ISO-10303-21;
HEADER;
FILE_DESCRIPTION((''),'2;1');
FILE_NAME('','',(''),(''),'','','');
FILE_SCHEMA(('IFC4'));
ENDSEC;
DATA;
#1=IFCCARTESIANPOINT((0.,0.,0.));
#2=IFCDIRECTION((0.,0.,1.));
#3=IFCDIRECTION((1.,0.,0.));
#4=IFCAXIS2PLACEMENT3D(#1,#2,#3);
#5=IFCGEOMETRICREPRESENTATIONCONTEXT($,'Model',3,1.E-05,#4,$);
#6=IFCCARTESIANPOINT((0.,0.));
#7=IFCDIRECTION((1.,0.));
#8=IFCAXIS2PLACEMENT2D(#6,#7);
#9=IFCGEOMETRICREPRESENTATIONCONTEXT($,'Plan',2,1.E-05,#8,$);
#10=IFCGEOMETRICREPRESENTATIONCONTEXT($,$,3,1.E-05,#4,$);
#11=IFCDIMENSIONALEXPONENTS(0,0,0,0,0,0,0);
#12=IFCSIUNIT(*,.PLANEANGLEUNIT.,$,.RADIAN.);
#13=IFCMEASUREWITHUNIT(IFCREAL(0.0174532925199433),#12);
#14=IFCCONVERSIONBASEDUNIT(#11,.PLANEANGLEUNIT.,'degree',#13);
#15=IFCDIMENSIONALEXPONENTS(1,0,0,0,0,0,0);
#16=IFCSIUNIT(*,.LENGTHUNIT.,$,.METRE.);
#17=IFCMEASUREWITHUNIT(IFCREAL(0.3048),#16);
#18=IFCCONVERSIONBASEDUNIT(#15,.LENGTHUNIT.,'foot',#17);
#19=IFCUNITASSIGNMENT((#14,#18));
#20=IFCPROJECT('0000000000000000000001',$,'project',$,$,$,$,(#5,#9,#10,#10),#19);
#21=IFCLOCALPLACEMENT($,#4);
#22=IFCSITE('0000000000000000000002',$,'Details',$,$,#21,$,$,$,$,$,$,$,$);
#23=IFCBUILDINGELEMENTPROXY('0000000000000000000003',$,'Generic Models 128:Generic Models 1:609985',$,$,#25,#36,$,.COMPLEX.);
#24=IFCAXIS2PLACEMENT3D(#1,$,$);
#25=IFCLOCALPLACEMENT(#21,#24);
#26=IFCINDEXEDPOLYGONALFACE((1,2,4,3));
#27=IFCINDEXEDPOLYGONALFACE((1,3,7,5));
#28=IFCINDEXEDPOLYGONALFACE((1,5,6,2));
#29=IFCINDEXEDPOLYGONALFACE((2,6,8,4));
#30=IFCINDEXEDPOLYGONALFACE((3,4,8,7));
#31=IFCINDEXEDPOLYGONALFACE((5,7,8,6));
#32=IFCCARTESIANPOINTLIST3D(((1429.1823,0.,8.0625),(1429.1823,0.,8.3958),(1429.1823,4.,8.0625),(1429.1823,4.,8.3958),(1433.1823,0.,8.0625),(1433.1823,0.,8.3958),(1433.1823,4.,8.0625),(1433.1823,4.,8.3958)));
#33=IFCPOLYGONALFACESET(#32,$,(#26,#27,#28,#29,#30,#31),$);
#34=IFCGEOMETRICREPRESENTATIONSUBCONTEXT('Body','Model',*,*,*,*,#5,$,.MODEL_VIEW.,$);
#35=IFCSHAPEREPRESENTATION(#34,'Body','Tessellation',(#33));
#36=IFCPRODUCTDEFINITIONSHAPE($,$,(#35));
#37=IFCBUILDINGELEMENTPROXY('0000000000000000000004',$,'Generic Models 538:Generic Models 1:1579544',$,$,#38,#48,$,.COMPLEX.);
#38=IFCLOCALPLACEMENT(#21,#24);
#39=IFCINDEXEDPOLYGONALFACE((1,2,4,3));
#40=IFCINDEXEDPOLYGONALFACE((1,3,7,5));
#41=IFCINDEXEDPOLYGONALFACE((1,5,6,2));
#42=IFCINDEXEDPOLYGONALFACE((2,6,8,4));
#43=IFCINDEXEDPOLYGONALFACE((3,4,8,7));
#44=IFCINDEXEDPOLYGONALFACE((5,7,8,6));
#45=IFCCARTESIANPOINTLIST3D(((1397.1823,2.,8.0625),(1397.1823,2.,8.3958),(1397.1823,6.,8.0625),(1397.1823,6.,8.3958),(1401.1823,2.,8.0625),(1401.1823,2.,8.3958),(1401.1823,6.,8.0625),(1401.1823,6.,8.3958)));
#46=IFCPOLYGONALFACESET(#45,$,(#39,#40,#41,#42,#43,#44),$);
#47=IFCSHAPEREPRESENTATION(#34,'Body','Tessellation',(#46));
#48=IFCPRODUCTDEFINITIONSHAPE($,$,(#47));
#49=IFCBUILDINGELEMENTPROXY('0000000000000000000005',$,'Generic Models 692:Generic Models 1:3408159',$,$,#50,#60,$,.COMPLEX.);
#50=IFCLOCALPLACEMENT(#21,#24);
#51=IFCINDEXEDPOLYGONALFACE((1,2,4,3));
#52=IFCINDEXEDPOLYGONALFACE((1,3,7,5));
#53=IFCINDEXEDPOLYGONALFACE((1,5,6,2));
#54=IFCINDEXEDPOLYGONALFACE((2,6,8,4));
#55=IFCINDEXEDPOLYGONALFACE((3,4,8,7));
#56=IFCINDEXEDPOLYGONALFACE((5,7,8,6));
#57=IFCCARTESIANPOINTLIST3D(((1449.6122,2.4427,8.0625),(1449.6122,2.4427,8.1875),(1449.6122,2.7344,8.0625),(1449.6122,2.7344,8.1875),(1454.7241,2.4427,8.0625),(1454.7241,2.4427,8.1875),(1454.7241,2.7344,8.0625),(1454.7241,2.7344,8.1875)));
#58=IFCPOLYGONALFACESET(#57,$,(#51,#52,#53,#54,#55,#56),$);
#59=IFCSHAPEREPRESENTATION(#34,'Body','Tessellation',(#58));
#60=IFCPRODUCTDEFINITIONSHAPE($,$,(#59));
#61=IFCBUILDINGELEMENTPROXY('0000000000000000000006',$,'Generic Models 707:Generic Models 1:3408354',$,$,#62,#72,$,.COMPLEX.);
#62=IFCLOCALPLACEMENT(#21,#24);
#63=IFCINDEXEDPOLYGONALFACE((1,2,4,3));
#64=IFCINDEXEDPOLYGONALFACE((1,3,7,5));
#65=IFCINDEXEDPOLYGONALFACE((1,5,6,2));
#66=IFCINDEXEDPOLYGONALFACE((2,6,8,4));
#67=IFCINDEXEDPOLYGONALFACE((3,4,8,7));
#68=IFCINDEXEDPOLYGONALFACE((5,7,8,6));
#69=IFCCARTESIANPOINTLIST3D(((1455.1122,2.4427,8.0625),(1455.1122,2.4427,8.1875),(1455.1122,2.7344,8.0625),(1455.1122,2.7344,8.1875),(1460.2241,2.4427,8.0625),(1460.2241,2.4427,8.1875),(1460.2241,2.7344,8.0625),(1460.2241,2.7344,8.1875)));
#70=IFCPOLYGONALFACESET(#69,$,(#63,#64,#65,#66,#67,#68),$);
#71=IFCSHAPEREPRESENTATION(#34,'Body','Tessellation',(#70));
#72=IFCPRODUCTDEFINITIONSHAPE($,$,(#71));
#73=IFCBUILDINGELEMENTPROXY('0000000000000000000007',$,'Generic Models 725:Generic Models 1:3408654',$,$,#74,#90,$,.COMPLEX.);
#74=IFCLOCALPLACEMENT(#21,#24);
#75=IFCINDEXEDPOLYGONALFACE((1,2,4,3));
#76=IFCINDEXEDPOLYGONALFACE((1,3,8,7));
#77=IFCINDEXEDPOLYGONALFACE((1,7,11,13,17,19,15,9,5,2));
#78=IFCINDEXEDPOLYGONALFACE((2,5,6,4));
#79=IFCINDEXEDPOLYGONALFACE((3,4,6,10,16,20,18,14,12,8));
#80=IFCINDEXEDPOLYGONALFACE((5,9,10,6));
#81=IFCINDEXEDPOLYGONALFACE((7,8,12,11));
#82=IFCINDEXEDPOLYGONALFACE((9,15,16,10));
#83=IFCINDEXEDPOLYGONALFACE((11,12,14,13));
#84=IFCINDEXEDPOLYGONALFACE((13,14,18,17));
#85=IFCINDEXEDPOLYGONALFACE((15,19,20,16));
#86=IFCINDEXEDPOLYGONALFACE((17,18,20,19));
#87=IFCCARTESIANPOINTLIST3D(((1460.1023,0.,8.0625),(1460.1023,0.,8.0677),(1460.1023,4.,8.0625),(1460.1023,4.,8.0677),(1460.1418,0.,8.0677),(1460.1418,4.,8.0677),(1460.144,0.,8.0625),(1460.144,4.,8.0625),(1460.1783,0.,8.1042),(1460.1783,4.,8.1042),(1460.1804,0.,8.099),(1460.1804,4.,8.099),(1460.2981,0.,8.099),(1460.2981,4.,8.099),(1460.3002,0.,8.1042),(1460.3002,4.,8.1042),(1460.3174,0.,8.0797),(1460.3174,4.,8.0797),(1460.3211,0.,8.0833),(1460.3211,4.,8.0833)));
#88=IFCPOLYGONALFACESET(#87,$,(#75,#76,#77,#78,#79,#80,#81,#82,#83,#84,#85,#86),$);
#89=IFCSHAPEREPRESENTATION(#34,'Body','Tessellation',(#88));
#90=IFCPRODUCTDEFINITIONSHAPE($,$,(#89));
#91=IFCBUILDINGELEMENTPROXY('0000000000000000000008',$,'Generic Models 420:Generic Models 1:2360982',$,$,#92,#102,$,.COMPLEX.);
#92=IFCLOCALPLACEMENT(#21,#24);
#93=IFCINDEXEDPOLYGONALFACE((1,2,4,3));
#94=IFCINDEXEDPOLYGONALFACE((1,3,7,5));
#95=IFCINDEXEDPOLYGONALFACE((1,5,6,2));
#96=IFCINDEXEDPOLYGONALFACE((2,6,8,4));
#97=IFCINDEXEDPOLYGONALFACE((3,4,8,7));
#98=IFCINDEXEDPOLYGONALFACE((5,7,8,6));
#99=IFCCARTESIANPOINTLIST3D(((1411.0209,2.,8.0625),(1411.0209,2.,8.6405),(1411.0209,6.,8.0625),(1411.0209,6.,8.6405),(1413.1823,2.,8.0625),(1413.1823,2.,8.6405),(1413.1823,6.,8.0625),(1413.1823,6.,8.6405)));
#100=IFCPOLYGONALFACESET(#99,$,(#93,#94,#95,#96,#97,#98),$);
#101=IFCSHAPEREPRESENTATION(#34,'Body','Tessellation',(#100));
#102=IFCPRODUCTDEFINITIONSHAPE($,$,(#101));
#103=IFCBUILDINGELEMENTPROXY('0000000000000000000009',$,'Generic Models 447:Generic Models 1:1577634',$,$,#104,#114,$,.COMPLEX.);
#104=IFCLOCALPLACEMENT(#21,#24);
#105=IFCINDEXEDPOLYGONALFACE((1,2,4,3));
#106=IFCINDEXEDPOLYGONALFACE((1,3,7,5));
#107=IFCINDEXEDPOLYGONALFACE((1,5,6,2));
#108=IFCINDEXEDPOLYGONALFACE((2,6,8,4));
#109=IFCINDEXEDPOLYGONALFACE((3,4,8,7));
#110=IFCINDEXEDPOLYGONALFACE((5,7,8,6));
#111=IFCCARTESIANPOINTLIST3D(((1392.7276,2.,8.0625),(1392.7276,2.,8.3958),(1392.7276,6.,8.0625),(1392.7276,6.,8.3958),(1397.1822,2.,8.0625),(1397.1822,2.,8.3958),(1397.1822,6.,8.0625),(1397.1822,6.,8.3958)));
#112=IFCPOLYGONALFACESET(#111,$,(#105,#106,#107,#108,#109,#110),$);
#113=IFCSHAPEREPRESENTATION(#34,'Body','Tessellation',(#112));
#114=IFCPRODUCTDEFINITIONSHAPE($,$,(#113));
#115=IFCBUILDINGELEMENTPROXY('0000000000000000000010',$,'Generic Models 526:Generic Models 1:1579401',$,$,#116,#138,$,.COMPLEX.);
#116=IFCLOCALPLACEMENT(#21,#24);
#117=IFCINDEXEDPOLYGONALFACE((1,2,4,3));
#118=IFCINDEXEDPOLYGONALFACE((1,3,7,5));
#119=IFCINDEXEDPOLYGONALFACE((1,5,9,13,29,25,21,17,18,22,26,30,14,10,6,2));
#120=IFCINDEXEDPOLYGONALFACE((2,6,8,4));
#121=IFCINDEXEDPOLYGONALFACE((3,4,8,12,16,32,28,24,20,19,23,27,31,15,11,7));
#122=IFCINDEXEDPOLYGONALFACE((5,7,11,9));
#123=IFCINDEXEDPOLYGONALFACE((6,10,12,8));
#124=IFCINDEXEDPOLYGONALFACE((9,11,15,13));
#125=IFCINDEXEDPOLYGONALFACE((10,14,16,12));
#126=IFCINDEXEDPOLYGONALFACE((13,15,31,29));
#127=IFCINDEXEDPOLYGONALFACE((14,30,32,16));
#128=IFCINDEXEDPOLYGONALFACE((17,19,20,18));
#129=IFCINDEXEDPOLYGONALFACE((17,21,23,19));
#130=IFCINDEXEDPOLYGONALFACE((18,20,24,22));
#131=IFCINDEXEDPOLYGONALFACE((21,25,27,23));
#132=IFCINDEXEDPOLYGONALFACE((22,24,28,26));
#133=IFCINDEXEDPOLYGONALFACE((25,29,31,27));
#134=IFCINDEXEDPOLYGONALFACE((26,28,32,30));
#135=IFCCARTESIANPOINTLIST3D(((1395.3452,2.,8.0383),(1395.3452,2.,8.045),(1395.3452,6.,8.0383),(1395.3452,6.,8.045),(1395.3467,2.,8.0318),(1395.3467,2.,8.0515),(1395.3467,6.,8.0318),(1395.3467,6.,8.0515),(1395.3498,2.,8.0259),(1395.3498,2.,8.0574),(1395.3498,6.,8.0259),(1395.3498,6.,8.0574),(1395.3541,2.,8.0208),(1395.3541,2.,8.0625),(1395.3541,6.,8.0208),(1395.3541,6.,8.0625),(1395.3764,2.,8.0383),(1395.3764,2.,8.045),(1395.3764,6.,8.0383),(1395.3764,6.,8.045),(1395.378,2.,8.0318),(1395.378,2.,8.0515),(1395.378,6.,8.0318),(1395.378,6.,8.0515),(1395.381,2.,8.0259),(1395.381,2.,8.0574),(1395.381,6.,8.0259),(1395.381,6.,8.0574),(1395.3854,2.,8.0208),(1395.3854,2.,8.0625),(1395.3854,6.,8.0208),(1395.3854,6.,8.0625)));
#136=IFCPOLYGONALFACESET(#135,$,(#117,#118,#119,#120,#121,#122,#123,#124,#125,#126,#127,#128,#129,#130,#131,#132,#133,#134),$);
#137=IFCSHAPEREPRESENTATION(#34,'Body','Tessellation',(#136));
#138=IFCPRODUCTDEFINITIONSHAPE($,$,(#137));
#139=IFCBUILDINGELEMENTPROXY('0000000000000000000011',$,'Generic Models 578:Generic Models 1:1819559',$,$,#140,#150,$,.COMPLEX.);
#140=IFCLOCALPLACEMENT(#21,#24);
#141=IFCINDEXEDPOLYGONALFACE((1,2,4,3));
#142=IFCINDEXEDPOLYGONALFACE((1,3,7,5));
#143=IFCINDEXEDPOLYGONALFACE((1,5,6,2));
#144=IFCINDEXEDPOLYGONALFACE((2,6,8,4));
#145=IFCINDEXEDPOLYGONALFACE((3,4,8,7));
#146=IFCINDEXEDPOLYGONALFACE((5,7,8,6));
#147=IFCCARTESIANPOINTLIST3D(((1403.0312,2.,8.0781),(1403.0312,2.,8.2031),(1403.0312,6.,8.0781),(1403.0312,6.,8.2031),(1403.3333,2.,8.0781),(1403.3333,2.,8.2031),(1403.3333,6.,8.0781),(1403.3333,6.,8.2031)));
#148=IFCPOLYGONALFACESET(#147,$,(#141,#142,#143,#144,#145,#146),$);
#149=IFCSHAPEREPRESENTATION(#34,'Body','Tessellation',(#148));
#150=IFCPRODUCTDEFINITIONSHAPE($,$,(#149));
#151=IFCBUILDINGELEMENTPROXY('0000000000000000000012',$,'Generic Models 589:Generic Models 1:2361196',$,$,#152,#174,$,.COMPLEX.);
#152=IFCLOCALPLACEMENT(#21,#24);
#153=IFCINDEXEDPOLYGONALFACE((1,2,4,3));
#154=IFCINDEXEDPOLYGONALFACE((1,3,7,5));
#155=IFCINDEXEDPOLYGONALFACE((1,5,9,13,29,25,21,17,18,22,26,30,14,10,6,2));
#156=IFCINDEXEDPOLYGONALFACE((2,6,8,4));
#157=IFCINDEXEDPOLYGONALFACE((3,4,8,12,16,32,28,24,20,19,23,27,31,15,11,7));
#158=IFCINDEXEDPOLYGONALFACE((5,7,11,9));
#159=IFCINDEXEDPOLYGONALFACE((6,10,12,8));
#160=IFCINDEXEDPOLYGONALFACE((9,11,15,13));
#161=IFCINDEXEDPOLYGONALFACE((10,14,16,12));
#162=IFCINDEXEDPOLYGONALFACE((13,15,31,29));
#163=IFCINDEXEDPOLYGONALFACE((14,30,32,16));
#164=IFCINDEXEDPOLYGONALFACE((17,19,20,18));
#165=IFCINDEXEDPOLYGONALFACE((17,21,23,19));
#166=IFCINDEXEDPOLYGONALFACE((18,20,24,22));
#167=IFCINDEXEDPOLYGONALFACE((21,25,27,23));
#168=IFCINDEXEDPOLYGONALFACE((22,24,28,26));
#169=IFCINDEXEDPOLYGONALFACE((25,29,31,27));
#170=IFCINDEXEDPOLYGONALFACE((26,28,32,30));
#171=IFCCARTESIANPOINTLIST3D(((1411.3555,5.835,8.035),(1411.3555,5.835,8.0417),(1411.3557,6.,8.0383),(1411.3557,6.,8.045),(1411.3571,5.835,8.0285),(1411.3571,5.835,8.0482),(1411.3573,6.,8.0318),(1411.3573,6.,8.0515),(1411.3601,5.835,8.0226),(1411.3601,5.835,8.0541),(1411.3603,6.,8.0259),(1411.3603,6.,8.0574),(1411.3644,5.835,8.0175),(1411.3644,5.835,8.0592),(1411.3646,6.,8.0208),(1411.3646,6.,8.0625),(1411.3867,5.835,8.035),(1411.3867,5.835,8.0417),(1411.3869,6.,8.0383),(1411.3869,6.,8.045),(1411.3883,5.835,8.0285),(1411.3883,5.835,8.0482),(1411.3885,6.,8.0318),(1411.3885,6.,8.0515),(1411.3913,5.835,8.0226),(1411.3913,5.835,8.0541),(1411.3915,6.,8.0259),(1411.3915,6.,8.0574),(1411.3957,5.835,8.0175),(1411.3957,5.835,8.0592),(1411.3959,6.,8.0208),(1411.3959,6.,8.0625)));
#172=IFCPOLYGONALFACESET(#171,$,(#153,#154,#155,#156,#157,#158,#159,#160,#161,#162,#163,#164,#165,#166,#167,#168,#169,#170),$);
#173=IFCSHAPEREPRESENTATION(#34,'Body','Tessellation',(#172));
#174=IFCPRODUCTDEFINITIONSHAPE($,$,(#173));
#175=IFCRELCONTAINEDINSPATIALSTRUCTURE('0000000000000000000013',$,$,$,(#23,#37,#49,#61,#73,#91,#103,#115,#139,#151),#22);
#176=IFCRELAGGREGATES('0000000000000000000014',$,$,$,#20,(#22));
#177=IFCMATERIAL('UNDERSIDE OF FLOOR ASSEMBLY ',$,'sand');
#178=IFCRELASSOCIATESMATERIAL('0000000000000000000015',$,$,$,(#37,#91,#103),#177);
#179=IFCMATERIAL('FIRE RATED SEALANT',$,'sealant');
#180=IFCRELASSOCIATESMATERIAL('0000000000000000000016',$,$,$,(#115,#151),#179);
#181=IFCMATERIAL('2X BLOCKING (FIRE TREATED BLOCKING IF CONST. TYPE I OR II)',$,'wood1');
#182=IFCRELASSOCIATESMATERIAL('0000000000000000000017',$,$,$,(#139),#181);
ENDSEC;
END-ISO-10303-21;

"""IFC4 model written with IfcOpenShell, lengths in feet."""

from ifc_helpers import new_model, entity, si_unit, converted_unit, frame, origin_with_axes, origin_2d_with_axis, place, context, subcontext, project, spatial, polyline, line, indexed_curve, outline, extrude, material, element, save


model = new_model("IFC4")

# Units and contexts
model_context = context("Model", 3, precision=1e-05, world=origin_with_axes())
plan_context = context("Plan", 2, precision=1e-05, world=origin_2d_with_axis())
context_of_model = context(None, 3, precision=1e-05, world=origin_with_axes())
body_context = subcontext(model_context, "Body", "Model", "MODEL_VIEW")
ifc_project = project(units=[converted_unit("PLANEANGLEUNIT", "degree", entity("IfcReal", 0.0174532925199433), si_unit("PLANEANGLEUNIT", "RADIAN"), dimensions=[0, 0, 0, 0, 0, 0, 0]), converted_unit("LENGTHUNIT", "foot", entity("IfcReal", 0.3048), si_unit("LENGTHUNIT", "METRE"), dimensions=[1, 0, 0, 0, 0, 0, 0])], contexts=[model_context, plan_context, context_of_model, context_of_model])

# Site
site_placement = place(None, origin_with_axes())
site = spatial("IfcSite", under=ifc_project, at=site_placement, Name="Details")

# Building element proxies
proxy_1_placement = place(site_placement, frame((1429.1823, 4.0, 8.0625), z_axis=(0.0, -1.0, 0.0), x_axis=(0.0, 0.0, 1.0)))
element("IfcBuildingElementProxy", 1, at=proxy_1_placement, inside=site, Name="Generic Models 128:Generic Models 1:609985", PredefinedType="COMPLEX", context=body_context, shape_type="SweptSolid", body=[
    extrude(outline(polyline([(-0.1667, -2.0), (0.1667, -2.0), (0.1667, 2.0), (-0.1667, 2.0), (-0.1667, -2.0)])), frame((0.1667, -2.0, 0.0), z_axis=(0.0, 0.0, -1.0), x_axis=(-1.0, 0.0, 0.0)), (0.0, 0.0, -1.0), 4.0),
])
ifc_material_1 = material(Name="UNDERSIDE OF FLOOR ASSEMBLY ", Category="sand")
proxy_2_placement = place(site_placement, frame((1397.1823, 6.0, 8.0625), z_axis=(0.0, -1.0, 0.0), x_axis=(0.0, 0.0, 1.0)))
element("IfcBuildingElementProxy", 2, at=proxy_2_placement, inside=site, material=ifc_material_1, Name="Generic Models 538:Generic Models 1:1579544", PredefinedType="COMPLEX", context=body_context, shape_type="SweptSolid", body=[
    extrude(outline(polyline([(-0.1667, -2.0), (0.1667, -2.0), (0.1667, 2.0), (-0.1667, 2.0), (-0.1667, -2.0)])), frame((0.1667, -2.0, 0.0), z_axis=(0.0, 0.0, -1.0), x_axis=(1.0, 0.0, 0.0)), (0.0, 0.0, -1.0), 4.0),
])
for number, where, z_axis, x_axis, name in (
    (3, (1449.6122, 2.7344, 8.0625), (0.0, -1.0, 0.0), (1.0, 0.0, 0.0), "Generic Models 692:Generic Models 1:3408159"),
    (4, (1455.1122, 2.7344, 8.0625), (0.0, -1.0, 0.0), (1.0, 0.0, 0.0), "Generic Models 707:Generic Models 1:3408354"),
):
    element("IfcBuildingElementProxy", number, at=place(site_placement, frame(where, z_axis=z_axis, x_axis=x_axis)), inside=site, Name=name, PredefinedType="COMPLEX", context=body_context, shape_type="SweptSolid", body=[
        extrude(outline(polyline([(-0.0625, -2.556), (0.0625, -2.556), (0.0625, 2.556), (-0.0625, 2.556), (-0.0625, -2.556)])), frame((2.556, 0.0625, 0.0), z_axis=(0.0, 0.0, -1.0), x_axis=(0.0, 1.0, 0.0)), (0.0, 0.0, -1.0), 0.2917),
    ])
proxy_3_placement = place(site_placement, frame((1460.1023, 4.0, 8.0625), z_axis=(0.0, -1.0, 0.0), x_axis=(0.0, 0.0, 1.0)))
element("IfcBuildingElementProxy", 5, at=proxy_3_placement, inside=site, Name="Generic Models 725:Generic Models 1:3408654", PredefinedType="COMPLEX", context=body_context, shape_type="SweptSolid", body=[
    extrude(outline(polyline([(0.1082, 0.0), (0.1072, 0.0051), (0.0684, -0.0024), (0.0258, 0.0266), (-0.094, 0.0035), (-0.1105, -0.0209), (-0.1062, -0.0238), (-0.0909, -0.0012), (0.0246, 0.021), (0.0673, -0.0079), (0.1082, 0.0)])), frame((0.0205, -0.1063, 0.0), z_axis=(0.0, 0.0, -1.0), x_axis=(-0.189091, 0.98196, 0.0)), (0.0, 0.0, -1.0), 4.0),
])
proxy_4_placement = place(site_placement, frame((1411.0209, 6.0, 8.0625), z_axis=(0.0, -1.0, 0.0), x_axis=(0.0, 0.0, 1.0)))
element("IfcBuildingElementProxy", 6, at=proxy_4_placement, inside=site, material=ifc_material_1, Name="Generic Models 420:Generic Models 1:2360982", PredefinedType="COMPLEX", context=body_context, shape_type="SweptSolid", body=[
    extrude(outline(polyline([(-0.289, -1.0807), (0.289, -1.0807), (0.289, 1.0807), (-0.289, 1.0807), (-0.289, -1.0807)])), frame((0.289, -1.0807, 0.0), z_axis=(0.0, 0.0, -1.0), x_axis=(1.0, 0.0, 0.0)), (0.0, 0.0, -1.0), 4.0),
])
proxy_5_placement = place(site_placement, frame((1392.7276, 6.0, 8.0625), z_axis=(0.0, -1.0, 0.0), x_axis=(0.0, 0.0, 1.0)))
element("IfcBuildingElementProxy", 7, at=proxy_5_placement, inside=site, material=ifc_material_1, Name="Generic Models 447:Generic Models 1:1577634", PredefinedType="COMPLEX", context=body_context, shape_type="SweptSolid", body=[
    extrude(outline(indexed_curve([(-2.4546, -0.1667), (2.0, -0.1667), (2.0, 0.1667), (-2.4546, 0.1667)], segments=[line(3, 2), line(2, 1), line(1, 4), line(4, 3)], self_intersect=False)), frame((0.1667, -2.0, 0.0), z_axis=(0.0, 0.0, -1.0), x_axis=(0.0, 1.0, 0.0)), (0.0, 0.0, -1.0), 4.0),
])
ifc_material_2 = material(Name="FIRE RATED SEALANT", Category="sealant")
proxy_6_placement = place(site_placement, frame((1395.3854, 6.0, 8.0625), z_axis=(0.0, -1.0, 0.0), x_axis=(0.0, 0.0, -1.0)))
element("IfcBuildingElementProxy", 8, at=proxy_6_placement, inside=site, material=ifc_material_2, Name="Generic Models 526:Generic Models 1:1579401", PredefinedType="COMPLEX", context=body_context, shape_type="SweptSolid", body=[
    extrude(outline(polyline([(0.0216, 0.0), (0.0223, 0.0066), (0.001, 0.0294), (0.0002, 0.0228), (-0.002, 0.0165), (-0.0057, 0.0109), (-0.0105, 0.0064), (-0.0163, 0.0031), (-0.0228, 0.0012), (-0.0294, 0.0009), (-0.008, -0.0219), (-0.0014, -0.0216), (0.005, -0.0197), (0.0108, -0.0164), (0.0157, -0.0119), (0.0194, -0.0063), (0.0216, 0.0)])), frame((0.0208, -0.0208, 0.0), z_axis=(0.0, 0.0, -1.0), x_axis=(-0.729168, -0.684334, 0.0)), (0.0, 0.0, -1.0), 4.0),
])
ifc_material_3 = material(Name="2X BLOCKING (FIRE TREATED BLOCKING IF CONST. TYPE I OR II)", Category="wood1")
proxy_7_placement = place(site_placement, frame((1403.0312, 6.0, 8.0781), z_axis=(0.0, -1.0, 0.0), x_axis=(0.0, 0.0, 1.0)))
element("IfcBuildingElementProxy", 9, at=proxy_7_placement, inside=site, material=ifc_material_3, Name="Generic Models 578:Generic Models 1:1819559", PredefinedType="COMPLEX", context=body_context, shape_type="SweptSolid", body=[
    extrude(outline(polyline([(-0.0625, -0.151), (0.0625, -0.151), (0.0625, 0.151), (-0.0625, 0.151), (-0.0625, -0.151)])), frame((0.0625, -0.151, 0.0), z_axis=(0.0, 0.0, -1.0), x_axis=(-1.0, 0.0, 0.0)), (0.0, 0.0, -1.0), 4.0),
])
proxy_8_placement = place(site_placement, frame((1411.3557, 6.0, 8.0208), z_axis=(0.0, -1.0, 0.0), x_axis=(0.0, 0.0, 1.0)))
element("IfcBuildingElementProxy", 10, at=proxy_8_placement, inside=site, material=ifc_material_2, Name="Generic Models 589:Generic Models 1:2361196", PredefinedType="COMPLEX", context=body_context, shape_type="SweptSolid", body=[
    extrude(outline(polyline([(0.0204, 0.0), (0.0206, 0.0067), (0.0192, 0.0132), (-0.0082, 0.0283), (-0.0068, 0.0217), (-0.007, 0.0151), (-0.0088, 0.0086), (-0.012, 0.0028), (-0.0165, -0.0021), (-0.022, -0.0059), (-0.0283, -0.0082), (-0.0009, -0.0233), (0.0054, -0.021), (0.0109, -0.0172), (0.0154, -0.0123), (0.0186, -0.0064), (0.0204, 0.0)])), frame((0.0208, -0.0194, 0.0), z_axis=(0.0, 0.0, -1.0), x_axis=(0.482454, 0.875921, 0.0)), (-0.008711, -0.018298, -0.999795), 0.165),
])

save(model, "model.ifc")
